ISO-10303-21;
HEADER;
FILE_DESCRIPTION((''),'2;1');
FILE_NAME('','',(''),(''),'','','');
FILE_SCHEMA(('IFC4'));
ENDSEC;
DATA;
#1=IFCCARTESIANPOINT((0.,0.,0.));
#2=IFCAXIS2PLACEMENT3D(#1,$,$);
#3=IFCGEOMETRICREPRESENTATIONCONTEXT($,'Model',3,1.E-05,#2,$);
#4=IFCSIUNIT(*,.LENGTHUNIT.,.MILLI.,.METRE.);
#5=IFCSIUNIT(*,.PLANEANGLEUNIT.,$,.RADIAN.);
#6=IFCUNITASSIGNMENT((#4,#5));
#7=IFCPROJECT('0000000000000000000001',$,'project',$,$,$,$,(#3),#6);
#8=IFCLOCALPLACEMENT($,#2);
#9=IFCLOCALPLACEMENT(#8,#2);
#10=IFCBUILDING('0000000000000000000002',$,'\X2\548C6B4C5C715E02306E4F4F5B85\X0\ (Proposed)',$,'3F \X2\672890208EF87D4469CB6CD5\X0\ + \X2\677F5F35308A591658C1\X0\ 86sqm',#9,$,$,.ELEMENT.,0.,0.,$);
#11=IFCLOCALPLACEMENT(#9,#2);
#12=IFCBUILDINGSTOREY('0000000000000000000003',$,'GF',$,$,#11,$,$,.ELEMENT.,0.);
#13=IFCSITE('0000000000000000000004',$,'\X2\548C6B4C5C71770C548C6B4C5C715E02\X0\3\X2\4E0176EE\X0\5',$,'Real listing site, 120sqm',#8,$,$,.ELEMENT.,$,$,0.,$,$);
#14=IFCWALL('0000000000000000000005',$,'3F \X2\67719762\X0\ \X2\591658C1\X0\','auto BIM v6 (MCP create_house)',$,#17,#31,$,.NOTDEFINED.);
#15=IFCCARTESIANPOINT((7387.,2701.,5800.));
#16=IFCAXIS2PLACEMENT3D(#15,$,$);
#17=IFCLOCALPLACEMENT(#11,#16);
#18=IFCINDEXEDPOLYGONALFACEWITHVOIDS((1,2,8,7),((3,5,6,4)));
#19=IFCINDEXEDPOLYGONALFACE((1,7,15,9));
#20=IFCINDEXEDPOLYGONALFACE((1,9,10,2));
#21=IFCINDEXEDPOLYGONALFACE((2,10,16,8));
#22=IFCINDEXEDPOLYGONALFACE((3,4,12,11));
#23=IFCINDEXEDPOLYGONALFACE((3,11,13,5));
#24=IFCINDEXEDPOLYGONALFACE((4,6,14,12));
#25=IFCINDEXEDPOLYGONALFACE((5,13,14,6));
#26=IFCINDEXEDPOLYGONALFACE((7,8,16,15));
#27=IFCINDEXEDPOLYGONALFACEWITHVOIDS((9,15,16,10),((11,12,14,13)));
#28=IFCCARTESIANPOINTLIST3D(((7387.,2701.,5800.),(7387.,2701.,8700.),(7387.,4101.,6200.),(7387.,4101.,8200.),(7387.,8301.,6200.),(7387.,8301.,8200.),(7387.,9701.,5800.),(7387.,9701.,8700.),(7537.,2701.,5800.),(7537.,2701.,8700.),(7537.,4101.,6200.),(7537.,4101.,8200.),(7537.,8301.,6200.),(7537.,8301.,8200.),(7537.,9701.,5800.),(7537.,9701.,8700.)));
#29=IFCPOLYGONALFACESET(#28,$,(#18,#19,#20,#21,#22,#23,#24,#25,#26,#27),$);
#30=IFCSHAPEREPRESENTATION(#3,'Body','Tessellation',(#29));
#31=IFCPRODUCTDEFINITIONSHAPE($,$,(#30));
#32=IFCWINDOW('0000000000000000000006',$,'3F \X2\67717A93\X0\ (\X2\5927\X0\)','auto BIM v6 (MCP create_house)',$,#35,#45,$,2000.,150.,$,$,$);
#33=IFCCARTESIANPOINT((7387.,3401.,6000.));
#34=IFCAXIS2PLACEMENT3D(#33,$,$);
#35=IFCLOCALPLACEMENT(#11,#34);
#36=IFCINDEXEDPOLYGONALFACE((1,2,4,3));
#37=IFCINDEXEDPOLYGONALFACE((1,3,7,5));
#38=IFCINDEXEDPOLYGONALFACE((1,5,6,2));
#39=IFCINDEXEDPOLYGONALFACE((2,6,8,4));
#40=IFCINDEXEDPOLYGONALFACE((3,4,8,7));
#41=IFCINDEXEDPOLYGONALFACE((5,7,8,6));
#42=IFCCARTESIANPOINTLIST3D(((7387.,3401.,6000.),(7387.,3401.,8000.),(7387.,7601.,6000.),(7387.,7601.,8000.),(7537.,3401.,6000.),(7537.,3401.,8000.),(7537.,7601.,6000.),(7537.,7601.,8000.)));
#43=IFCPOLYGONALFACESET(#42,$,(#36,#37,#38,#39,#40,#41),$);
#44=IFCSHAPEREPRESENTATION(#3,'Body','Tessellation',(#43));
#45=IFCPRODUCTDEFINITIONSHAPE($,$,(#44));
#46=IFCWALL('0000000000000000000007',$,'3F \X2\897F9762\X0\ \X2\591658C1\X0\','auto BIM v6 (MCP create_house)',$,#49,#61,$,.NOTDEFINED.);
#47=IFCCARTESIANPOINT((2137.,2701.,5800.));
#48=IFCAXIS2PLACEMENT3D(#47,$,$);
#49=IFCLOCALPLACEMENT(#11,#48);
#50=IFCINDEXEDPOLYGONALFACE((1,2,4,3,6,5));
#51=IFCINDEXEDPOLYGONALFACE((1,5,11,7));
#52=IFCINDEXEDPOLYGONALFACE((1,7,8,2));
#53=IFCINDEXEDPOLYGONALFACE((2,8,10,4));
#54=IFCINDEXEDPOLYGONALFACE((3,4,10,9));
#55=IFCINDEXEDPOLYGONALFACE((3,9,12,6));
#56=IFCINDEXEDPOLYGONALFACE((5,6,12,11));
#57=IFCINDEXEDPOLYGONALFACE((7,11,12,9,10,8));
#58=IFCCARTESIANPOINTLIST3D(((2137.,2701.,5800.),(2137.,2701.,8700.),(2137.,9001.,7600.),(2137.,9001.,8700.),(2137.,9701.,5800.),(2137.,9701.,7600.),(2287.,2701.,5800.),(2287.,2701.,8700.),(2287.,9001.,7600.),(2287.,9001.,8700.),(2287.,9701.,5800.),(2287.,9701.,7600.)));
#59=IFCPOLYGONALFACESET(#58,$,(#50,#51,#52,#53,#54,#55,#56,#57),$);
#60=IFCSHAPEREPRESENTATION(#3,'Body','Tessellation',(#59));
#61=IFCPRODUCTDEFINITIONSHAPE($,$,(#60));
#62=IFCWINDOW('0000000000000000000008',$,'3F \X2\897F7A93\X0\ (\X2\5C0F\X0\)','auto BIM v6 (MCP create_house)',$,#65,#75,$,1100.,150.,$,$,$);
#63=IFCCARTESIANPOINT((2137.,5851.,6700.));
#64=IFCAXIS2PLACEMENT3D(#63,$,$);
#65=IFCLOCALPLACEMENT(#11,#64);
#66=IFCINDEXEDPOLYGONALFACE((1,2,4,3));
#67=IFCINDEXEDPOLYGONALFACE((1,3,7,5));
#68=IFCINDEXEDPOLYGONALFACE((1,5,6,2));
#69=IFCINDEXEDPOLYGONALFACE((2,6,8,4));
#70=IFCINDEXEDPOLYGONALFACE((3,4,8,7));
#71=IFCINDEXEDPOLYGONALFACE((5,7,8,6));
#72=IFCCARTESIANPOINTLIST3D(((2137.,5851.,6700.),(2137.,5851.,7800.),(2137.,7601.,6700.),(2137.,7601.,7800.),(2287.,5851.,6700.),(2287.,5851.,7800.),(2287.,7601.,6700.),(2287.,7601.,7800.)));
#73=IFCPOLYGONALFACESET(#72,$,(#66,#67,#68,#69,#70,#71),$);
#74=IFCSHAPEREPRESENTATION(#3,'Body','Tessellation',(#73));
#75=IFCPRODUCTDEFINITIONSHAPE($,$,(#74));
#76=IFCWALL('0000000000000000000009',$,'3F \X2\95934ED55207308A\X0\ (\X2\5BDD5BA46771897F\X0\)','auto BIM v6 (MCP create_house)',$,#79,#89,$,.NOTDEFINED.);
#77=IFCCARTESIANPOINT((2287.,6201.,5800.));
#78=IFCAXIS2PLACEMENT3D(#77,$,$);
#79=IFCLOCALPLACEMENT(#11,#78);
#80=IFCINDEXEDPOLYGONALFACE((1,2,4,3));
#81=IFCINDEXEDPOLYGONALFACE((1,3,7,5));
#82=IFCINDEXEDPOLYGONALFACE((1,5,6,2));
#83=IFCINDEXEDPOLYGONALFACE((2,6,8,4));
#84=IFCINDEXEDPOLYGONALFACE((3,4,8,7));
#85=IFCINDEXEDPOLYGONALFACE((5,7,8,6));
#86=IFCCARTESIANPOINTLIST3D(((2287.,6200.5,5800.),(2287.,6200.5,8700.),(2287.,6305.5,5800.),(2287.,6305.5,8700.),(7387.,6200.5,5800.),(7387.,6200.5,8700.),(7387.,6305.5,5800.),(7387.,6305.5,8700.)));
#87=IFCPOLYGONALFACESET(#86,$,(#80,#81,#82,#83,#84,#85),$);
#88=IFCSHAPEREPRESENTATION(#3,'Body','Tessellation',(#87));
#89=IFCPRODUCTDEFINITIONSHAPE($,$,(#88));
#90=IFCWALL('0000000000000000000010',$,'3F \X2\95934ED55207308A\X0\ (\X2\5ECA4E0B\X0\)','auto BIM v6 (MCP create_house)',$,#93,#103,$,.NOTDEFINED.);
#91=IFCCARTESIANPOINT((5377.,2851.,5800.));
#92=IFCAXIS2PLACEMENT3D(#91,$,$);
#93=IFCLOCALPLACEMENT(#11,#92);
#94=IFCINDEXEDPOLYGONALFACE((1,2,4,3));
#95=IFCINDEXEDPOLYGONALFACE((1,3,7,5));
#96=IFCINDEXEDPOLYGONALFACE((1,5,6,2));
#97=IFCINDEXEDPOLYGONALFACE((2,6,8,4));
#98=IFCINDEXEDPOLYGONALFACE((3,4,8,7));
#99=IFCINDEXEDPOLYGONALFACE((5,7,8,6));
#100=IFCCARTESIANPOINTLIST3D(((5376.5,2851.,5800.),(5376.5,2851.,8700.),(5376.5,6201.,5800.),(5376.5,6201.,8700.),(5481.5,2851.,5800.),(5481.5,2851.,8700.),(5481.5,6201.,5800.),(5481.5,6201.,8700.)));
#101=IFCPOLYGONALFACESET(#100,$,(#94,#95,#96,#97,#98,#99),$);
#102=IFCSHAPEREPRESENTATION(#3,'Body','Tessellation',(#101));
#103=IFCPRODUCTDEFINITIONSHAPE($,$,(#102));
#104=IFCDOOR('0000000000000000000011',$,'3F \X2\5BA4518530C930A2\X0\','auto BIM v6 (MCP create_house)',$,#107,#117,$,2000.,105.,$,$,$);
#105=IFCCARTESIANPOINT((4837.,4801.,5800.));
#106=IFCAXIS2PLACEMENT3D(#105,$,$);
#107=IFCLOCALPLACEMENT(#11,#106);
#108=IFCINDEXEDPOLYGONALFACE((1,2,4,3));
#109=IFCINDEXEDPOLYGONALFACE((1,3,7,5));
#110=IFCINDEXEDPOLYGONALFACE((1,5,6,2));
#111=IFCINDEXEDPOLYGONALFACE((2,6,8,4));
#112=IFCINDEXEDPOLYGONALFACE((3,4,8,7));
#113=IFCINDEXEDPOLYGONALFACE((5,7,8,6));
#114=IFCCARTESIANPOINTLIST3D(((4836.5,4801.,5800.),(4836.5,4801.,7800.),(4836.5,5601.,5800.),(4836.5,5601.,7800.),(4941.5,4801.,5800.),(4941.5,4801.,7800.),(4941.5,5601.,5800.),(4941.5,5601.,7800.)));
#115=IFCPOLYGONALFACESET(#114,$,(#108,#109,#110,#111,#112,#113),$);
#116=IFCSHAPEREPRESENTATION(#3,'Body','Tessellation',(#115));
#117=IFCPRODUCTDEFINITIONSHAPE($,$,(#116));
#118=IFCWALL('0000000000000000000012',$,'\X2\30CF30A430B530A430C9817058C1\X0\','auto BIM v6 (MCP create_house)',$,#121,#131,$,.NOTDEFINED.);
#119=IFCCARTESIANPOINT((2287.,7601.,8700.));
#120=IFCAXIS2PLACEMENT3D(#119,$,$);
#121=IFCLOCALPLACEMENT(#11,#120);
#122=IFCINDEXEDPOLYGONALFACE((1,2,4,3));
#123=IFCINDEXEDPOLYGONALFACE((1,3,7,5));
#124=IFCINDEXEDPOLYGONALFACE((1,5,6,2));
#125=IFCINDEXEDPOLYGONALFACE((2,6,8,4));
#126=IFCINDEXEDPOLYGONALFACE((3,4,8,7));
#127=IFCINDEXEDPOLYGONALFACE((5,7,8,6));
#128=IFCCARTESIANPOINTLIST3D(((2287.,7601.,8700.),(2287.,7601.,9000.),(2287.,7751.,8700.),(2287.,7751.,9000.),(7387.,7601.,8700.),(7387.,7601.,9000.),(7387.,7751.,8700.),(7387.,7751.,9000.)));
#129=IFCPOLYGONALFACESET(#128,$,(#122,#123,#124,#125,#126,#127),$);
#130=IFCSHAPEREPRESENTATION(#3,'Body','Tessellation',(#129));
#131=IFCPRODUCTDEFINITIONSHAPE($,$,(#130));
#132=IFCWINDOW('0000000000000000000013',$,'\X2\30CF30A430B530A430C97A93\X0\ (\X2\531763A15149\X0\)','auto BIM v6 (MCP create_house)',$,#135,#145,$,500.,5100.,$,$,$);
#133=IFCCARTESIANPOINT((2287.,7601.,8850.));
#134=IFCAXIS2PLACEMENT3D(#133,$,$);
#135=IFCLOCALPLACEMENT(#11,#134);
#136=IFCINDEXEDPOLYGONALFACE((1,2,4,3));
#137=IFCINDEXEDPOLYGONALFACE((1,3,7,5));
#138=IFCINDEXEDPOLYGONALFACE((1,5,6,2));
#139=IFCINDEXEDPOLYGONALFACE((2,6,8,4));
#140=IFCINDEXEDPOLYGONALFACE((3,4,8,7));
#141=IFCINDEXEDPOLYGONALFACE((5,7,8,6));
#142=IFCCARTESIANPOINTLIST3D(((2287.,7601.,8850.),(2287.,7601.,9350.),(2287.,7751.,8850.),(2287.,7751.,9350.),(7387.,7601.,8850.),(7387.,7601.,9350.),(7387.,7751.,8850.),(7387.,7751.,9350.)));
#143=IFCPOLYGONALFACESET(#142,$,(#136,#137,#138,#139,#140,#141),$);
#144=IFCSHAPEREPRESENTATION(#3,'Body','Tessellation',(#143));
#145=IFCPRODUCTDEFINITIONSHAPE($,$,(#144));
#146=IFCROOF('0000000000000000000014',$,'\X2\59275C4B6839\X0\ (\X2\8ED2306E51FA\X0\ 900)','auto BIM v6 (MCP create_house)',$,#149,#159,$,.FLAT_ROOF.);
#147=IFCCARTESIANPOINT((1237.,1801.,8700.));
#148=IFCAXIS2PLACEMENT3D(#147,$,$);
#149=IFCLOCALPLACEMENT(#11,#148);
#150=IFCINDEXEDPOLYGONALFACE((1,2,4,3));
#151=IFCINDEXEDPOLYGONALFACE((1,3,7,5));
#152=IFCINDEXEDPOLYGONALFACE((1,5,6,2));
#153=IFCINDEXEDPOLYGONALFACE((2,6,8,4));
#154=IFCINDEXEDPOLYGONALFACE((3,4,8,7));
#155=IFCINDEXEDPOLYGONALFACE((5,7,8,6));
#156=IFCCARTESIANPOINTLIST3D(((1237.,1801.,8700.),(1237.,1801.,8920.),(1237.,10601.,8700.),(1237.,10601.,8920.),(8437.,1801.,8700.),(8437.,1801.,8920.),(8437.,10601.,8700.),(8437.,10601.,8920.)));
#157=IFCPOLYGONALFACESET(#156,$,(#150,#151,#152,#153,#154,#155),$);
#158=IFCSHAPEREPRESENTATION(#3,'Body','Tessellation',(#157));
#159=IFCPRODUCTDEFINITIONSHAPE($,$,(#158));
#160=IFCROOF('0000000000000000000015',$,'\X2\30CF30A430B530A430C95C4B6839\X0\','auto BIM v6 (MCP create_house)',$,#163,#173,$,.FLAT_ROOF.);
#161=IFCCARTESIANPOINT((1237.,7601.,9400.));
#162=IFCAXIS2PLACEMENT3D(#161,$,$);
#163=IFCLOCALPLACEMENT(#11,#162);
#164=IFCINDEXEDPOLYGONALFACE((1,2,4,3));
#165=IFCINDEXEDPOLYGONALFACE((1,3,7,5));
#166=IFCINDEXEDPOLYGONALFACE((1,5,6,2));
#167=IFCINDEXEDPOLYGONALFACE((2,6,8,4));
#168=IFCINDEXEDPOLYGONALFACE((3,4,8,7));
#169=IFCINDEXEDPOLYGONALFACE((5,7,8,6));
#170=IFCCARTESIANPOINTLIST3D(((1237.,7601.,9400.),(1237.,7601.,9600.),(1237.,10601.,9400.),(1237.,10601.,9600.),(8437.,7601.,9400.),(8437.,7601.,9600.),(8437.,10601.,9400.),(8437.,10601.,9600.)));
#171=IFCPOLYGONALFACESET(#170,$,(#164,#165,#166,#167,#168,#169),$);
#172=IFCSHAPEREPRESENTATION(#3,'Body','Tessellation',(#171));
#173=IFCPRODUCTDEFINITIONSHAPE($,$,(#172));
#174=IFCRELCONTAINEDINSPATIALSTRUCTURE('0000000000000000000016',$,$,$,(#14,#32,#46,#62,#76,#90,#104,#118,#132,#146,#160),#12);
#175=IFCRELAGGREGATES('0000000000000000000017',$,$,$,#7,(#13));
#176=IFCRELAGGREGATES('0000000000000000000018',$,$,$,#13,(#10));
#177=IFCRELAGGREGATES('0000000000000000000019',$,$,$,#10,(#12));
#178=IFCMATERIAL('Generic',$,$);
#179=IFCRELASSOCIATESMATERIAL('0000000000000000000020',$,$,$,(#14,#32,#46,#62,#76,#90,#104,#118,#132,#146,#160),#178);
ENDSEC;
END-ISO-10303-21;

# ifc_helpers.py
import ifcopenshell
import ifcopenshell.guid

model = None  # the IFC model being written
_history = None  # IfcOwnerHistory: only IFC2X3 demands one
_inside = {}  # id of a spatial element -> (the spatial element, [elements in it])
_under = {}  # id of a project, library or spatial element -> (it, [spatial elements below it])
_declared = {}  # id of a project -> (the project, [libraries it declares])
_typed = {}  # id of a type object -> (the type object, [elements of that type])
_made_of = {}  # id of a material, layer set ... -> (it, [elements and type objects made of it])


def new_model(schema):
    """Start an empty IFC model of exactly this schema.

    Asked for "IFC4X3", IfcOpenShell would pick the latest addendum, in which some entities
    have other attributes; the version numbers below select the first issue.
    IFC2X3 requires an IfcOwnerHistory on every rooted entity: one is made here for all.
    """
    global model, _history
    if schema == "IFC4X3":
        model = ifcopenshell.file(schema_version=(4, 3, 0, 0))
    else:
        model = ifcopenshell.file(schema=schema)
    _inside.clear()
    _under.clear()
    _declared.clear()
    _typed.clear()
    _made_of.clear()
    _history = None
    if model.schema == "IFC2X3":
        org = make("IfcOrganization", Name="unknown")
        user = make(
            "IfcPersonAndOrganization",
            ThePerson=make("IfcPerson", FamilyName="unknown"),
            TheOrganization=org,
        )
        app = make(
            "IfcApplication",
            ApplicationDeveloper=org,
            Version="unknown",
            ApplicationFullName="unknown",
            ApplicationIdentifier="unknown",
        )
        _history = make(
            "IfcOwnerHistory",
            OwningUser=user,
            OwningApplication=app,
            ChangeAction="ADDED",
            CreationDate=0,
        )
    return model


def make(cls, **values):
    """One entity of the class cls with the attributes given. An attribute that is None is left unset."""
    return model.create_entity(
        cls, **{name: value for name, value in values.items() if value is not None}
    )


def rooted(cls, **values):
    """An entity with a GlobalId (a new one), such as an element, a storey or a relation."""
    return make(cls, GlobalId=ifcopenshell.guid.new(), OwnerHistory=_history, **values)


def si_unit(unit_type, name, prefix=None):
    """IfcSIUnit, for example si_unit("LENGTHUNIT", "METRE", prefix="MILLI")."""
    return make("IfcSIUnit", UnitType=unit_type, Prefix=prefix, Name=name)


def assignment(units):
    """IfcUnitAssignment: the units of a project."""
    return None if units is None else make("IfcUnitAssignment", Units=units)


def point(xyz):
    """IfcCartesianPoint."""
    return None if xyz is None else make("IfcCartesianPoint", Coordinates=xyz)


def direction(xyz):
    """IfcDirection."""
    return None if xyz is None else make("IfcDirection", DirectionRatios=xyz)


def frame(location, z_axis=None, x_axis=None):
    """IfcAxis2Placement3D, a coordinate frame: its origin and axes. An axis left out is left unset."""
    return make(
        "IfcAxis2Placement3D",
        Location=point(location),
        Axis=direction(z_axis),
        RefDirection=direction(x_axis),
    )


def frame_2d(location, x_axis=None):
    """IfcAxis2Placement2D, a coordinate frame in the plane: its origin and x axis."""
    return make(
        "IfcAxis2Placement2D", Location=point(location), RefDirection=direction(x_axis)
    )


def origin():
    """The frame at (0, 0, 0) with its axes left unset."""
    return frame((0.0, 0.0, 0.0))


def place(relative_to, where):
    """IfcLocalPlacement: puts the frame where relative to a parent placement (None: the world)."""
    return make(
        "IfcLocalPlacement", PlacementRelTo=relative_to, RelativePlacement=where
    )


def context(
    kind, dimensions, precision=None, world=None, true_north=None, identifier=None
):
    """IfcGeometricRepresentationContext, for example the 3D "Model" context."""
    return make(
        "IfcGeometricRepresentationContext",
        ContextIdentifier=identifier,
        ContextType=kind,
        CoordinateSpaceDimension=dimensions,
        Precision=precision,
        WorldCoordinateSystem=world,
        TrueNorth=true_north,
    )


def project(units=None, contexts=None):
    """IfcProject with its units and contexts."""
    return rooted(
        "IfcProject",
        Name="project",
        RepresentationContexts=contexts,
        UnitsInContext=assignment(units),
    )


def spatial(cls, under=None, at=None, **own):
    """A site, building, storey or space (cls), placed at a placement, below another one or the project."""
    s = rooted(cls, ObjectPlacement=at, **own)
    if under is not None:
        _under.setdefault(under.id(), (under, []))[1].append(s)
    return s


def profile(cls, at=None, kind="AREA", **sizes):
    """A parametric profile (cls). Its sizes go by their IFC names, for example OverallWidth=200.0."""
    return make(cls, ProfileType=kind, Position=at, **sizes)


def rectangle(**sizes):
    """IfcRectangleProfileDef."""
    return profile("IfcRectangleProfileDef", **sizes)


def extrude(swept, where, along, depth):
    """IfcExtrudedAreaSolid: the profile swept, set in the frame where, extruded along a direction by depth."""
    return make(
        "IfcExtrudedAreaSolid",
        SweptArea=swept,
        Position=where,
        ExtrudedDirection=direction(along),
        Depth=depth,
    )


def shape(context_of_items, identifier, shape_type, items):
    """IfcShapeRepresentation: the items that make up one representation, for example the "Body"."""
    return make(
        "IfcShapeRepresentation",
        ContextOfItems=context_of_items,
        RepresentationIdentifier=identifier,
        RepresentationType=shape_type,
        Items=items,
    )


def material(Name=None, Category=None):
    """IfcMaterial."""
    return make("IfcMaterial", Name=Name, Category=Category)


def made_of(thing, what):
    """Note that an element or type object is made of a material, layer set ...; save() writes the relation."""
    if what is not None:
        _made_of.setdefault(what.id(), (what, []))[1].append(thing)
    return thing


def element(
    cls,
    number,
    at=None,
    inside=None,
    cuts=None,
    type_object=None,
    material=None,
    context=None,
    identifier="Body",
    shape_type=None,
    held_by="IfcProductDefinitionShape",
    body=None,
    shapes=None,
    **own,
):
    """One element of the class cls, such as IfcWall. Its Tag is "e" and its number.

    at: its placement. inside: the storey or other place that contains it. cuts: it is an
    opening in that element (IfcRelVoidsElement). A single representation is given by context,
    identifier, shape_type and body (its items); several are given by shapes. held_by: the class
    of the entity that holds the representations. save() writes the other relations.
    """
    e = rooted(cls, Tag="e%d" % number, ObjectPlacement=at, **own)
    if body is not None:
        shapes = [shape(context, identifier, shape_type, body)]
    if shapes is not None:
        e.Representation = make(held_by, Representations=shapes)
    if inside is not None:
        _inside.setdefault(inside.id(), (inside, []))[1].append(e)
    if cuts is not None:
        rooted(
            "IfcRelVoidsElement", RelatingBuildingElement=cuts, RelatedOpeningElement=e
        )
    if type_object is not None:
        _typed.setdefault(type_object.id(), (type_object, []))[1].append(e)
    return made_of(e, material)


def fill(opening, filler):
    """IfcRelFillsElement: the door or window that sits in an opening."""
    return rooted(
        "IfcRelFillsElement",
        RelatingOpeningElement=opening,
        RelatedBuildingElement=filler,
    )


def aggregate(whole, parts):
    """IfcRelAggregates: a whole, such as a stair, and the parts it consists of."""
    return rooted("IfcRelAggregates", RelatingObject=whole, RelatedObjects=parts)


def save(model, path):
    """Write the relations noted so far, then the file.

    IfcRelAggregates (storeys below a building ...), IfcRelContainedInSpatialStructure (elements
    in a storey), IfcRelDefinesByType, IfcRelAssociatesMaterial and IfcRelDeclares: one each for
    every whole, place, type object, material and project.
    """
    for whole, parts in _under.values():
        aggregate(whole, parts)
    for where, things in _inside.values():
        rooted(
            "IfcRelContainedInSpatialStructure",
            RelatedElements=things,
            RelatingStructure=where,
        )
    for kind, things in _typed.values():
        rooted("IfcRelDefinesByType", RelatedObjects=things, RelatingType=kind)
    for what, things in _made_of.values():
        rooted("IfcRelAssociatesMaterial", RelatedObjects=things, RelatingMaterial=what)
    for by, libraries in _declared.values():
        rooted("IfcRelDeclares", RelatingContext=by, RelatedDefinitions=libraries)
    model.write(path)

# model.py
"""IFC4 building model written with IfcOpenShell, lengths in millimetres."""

from ifc_helpers import new_model, si_unit, frame, frame_2d, origin, place, context, project, spatial, rectangle, extrude, material, element, fill, save


model = new_model("IFC4")

# Units and contexts
model_context = context("Model", 3, precision=1e-05, world=origin())
ifc_project = project(units=[si_unit("LENGTHUNIT", "METRE", prefix="MILLI"), si_unit("PLANEANGLEUNIT", "RADIAN")], contexts=[model_context])

# Site, building, storey
site_placement = place(None, origin())
site = spatial("IfcSite", under=ifc_project, at=site_placement, Name="和歌山県和歌山市3丁目5", ObjectType="Real listing site, 120sqm", CompositionType="ELEMENT", RefElevation=0.0)
building_placement = place(site_placement, origin())
building = spatial("IfcBuilding", under=site, at=building_placement, Name="和歌山市の住宅 (Proposed)", ObjectType="3F 木造軸組構法 + 板張り外壁 86sqm", CompositionType="ELEMENT", ElevationOfRefHeight=0.0, ElevationOfTerrain=0.0)
storey_placement = place(building_placement, origin())
storey = spatial("IfcBuildingStorey", under=building, at=storey_placement, Name="GF", CompositionType="ELEMENT", Elevation=0.0)

# Shared definitions
ifc_material = material(Name="Generic")

# Walls, openings, windows
wall_1_placement = place(storey_placement, frame((7387.0, 2701.0, 5800.0)))
wall_1 = element("IfcWall", 1, at=wall_1_placement, inside=storey, material=ifc_material, Name="3F 東面 外壁", Description="auto BIM v6 (MCP create_house)", PredefinedType="NOTDEFINED", context=model_context, shape_type="SweptSolid", body=[
    extrude(rectangle(XDim=150.0, YDim=7000.0, at=frame_2d((75.0, 3500.0))), frame((7387.0, 2701.0, 5800.0)), (0.0, 0.0, 1.0), 2900.0),
])
opening_1_placement = place(storey_placement, frame((7387.0, 3401.0, 6000.0)))
opening_1 = element("IfcOpeningElement", 2, at=opening_1_placement, cuts=wall_1, PredefinedType="NOTDEFINED", context=model_context, shape_type="SweptSolid", body=[
    extrude(rectangle(XDim=150.0, YDim=4200.0, at=frame_2d((75.0, 2100.0))), frame((7387.0, 3401.0, 6000.0)), (0.0, 0.0, 1.0), 2000.0),
])
window_1_placement = place(storey_placement, frame((7387.0, 3401.0, 6000.0)))
window_1 = element("IfcWindow", 3, at=window_1_placement, inside=storey, material=ifc_material, Name="3F 東窓 (大)", Description="auto BIM v6 (MCP create_house)", OverallHeight=2000.0, OverallWidth=150.0, context=model_context, shape_type="SweptSolid", body=[
    extrude(rectangle(XDim=150.0, YDim=4200.0, at=frame_2d((75.0, 2100.0))), frame((7387.0, 3401.0, 6000.0)), (0.0, 0.0, 1.0), 2000.0),
])
fill(opening_1, window_1)
wall_2_placement = place(storey_placement, frame((2137.0, 2701.0, 5800.0)))
wall_2 = element("IfcWall", 4, at=wall_2_placement, inside=storey, material=ifc_material, Name="3F 西面 外壁", Description="auto BIM v6 (MCP create_house)", PredefinedType="NOTDEFINED", context=model_context, shape_type="SweptSolid", body=[
    extrude(rectangle(XDim=150.0, YDim=7000.0, at=frame_2d((75.0, 3500.0))), frame((2137.0, 2701.0, 5800.0)), (0.0, 0.0, 1.0), 2900.0),
])
opening_2_placement = place(storey_placement, frame((2137.0, 5851.0, 6700.0)))
opening_2 = element("IfcOpeningElement", 5, at=opening_2_placement, cuts=wall_2, PredefinedType="NOTDEFINED", context=model_context, shape_type="SweptSolid", body=[
    extrude(rectangle(XDim=150.0, YDim=1750.0, at=frame_2d((75.0, 875.0))), frame((2137.0, 5851.0, 6700.0)), (0.0, 0.0, 1.0), 1100.0),
])
window_2_placement = place(storey_placement, frame((2137.0, 5851.0, 6700.0)))
window_2 = element("IfcWindow", 6, at=window_2_placement, inside=storey, material=ifc_material, Name="3F 西窓 (小)", Description="auto BIM v6 (MCP create_house)", OverallHeight=1100.0, OverallWidth=150.0, context=model_context, shape_type="SweptSolid", body=[
    extrude(rectangle(XDim=150.0, YDim=1750.0, at=frame_2d((75.0, 875.0))), frame((2137.0, 5851.0, 6700.0)), (0.0, 0.0, 1.0), 1100.0),
])
fill(opening_2, window_2)

# Walls
wall_3_placement = place(storey_placement, frame((2287.0, 6201.0, 5800.0)))
element("IfcWall", 7, at=wall_3_placement, inside=storey, material=ifc_material, Name="3F 間仕切り (寝室東西)", Description="auto BIM v6 (MCP create_house)", PredefinedType="NOTDEFINED", context=model_context, shape_type="SweptSolid", body=[
    extrude(rectangle(XDim=5100.0, YDim=105.0, at=frame_2d((2550.0, 52.0))), frame((2287.0, 6201.0, 5800.0)), (0.0, 0.0, 1.0), 2900.0),
])
wall_4_placement = place(storey_placement, frame((5377.0, 2851.0, 5800.0)))
element("IfcWall", 8, at=wall_4_placement, inside=storey, material=ifc_material, Name="3F 間仕切り (廊下)", Description="auto BIM v6 (MCP create_house)", PredefinedType="NOTDEFINED", context=model_context, shape_type="SweptSolid", body=[
    extrude(rectangle(XDim=105.0, YDim=3350.0, at=frame_2d((52.0, 1675.0))), frame((5377.0, 2851.0, 5800.0)), (0.0, 0.0, 1.0), 2900.0),
])

# Door
door_1_placement = place(storey_placement, frame((4837.0, 4801.0, 5800.0)))
element("IfcDoor", 9, at=door_1_placement, inside=storey, material=ifc_material, Name="3F 室内ドア", Description="auto BIM v6 (MCP create_house)", OverallHeight=2000.0, OverallWidth=105.0, context=model_context, shape_type="SweptSolid", body=[
    extrude(rectangle(XDim=105.0, YDim=800.0, at=frame_2d((52.0, 400.0))), frame((4837.0, 4801.0, 5800.0)), (0.0, 0.0, 1.0), 2000.0),
])

# Wall, opening, window
wall_5_placement = place(storey_placement, frame((2287.0, 7601.0, 8700.0)))
wall_5 = element("IfcWall", 10, at=wall_5_placement, inside=storey, material=ifc_material, Name="ハイサイド腰壁", Description="auto BIM v6 (MCP create_house)", PredefinedType="NOTDEFINED", context=model_context, shape_type="SweptSolid", body=[
    extrude(rectangle(XDim=5100.0, YDim=150.0, at=frame_2d((2550.0, 75.0))), frame((2287.0, 7601.0, 8700.0)), (0.0, 0.0, 1.0), 700.0),
])
opening_3_placement = place(storey_placement, frame((2287.0, 7601.0, 8850.0)))
opening_3 = element("IfcOpeningElement", 11, at=opening_3_placement, cuts=wall_5, PredefinedType="NOTDEFINED", context=model_context, shape_type="SweptSolid", body=[
    extrude(rectangle(XDim=5100.0, YDim=150.0, at=frame_2d((2550.0, 75.0))), frame((2287.0, 7601.0, 8850.0)), (0.0, 0.0, 1.0), 500.0),
])
window_3_placement = place(storey_placement, frame((2287.0, 7601.0, 8850.0)))
window_3 = element("IfcWindow", 12, at=window_3_placement, inside=storey, material=ifc_material, Name="ハイサイド窓 (北採光)", Description="auto BIM v6 (MCP create_house)", OverallHeight=500.0, OverallWidth=5100.0, context=model_context, shape_type="SweptSolid", body=[
    extrude(rectangle(XDim=5100.0, YDim=150.0, at=frame_2d((2550.0, 75.0))), frame((2287.0, 7601.0, 8850.0)), (0.0, 0.0, 1.0), 500.0),
])
fill(opening_3, window_3)

# Roofs
roof_1_placement = place(storey_placement, frame((1237.0, 1801.0, 8700.0)))
element("IfcRoof", 13, at=roof_1_placement, inside=storey, material=ifc_material, Name="大屋根 (軒の出 900)", Description="auto BIM v6 (MCP create_house)", PredefinedType="FLAT_ROOF", context=model_context, shape_type="SweptSolid", body=[
    extrude(rectangle(XDim=7200.0, YDim=8800.0, at=frame_2d((3600.0, 4400.0))), frame((1237.0, 1801.0, 8700.0)), (0.0, 0.0, 1.0), 220.0),
])
roof_2_placement = place(storey_placement, frame((1237.0, 7601.0, 9400.0)))
element("IfcRoof", 14, at=roof_2_placement, inside=storey, material=ifc_material, Name="ハイサイド屋根", Description="auto BIM v6 (MCP create_house)", PredefinedType="FLAT_ROOF", context=model_context, shape_type="SweptSolid", body=[
    extrude(rectangle(XDim=7200.0, YDim=3000.0, at=frame_2d((3600.0, 1500.0))), frame((1237.0, 7601.0, 9400.0)), (0.0, 0.0, 1.0), 200.0),
])

save(model, "model.ifc")
